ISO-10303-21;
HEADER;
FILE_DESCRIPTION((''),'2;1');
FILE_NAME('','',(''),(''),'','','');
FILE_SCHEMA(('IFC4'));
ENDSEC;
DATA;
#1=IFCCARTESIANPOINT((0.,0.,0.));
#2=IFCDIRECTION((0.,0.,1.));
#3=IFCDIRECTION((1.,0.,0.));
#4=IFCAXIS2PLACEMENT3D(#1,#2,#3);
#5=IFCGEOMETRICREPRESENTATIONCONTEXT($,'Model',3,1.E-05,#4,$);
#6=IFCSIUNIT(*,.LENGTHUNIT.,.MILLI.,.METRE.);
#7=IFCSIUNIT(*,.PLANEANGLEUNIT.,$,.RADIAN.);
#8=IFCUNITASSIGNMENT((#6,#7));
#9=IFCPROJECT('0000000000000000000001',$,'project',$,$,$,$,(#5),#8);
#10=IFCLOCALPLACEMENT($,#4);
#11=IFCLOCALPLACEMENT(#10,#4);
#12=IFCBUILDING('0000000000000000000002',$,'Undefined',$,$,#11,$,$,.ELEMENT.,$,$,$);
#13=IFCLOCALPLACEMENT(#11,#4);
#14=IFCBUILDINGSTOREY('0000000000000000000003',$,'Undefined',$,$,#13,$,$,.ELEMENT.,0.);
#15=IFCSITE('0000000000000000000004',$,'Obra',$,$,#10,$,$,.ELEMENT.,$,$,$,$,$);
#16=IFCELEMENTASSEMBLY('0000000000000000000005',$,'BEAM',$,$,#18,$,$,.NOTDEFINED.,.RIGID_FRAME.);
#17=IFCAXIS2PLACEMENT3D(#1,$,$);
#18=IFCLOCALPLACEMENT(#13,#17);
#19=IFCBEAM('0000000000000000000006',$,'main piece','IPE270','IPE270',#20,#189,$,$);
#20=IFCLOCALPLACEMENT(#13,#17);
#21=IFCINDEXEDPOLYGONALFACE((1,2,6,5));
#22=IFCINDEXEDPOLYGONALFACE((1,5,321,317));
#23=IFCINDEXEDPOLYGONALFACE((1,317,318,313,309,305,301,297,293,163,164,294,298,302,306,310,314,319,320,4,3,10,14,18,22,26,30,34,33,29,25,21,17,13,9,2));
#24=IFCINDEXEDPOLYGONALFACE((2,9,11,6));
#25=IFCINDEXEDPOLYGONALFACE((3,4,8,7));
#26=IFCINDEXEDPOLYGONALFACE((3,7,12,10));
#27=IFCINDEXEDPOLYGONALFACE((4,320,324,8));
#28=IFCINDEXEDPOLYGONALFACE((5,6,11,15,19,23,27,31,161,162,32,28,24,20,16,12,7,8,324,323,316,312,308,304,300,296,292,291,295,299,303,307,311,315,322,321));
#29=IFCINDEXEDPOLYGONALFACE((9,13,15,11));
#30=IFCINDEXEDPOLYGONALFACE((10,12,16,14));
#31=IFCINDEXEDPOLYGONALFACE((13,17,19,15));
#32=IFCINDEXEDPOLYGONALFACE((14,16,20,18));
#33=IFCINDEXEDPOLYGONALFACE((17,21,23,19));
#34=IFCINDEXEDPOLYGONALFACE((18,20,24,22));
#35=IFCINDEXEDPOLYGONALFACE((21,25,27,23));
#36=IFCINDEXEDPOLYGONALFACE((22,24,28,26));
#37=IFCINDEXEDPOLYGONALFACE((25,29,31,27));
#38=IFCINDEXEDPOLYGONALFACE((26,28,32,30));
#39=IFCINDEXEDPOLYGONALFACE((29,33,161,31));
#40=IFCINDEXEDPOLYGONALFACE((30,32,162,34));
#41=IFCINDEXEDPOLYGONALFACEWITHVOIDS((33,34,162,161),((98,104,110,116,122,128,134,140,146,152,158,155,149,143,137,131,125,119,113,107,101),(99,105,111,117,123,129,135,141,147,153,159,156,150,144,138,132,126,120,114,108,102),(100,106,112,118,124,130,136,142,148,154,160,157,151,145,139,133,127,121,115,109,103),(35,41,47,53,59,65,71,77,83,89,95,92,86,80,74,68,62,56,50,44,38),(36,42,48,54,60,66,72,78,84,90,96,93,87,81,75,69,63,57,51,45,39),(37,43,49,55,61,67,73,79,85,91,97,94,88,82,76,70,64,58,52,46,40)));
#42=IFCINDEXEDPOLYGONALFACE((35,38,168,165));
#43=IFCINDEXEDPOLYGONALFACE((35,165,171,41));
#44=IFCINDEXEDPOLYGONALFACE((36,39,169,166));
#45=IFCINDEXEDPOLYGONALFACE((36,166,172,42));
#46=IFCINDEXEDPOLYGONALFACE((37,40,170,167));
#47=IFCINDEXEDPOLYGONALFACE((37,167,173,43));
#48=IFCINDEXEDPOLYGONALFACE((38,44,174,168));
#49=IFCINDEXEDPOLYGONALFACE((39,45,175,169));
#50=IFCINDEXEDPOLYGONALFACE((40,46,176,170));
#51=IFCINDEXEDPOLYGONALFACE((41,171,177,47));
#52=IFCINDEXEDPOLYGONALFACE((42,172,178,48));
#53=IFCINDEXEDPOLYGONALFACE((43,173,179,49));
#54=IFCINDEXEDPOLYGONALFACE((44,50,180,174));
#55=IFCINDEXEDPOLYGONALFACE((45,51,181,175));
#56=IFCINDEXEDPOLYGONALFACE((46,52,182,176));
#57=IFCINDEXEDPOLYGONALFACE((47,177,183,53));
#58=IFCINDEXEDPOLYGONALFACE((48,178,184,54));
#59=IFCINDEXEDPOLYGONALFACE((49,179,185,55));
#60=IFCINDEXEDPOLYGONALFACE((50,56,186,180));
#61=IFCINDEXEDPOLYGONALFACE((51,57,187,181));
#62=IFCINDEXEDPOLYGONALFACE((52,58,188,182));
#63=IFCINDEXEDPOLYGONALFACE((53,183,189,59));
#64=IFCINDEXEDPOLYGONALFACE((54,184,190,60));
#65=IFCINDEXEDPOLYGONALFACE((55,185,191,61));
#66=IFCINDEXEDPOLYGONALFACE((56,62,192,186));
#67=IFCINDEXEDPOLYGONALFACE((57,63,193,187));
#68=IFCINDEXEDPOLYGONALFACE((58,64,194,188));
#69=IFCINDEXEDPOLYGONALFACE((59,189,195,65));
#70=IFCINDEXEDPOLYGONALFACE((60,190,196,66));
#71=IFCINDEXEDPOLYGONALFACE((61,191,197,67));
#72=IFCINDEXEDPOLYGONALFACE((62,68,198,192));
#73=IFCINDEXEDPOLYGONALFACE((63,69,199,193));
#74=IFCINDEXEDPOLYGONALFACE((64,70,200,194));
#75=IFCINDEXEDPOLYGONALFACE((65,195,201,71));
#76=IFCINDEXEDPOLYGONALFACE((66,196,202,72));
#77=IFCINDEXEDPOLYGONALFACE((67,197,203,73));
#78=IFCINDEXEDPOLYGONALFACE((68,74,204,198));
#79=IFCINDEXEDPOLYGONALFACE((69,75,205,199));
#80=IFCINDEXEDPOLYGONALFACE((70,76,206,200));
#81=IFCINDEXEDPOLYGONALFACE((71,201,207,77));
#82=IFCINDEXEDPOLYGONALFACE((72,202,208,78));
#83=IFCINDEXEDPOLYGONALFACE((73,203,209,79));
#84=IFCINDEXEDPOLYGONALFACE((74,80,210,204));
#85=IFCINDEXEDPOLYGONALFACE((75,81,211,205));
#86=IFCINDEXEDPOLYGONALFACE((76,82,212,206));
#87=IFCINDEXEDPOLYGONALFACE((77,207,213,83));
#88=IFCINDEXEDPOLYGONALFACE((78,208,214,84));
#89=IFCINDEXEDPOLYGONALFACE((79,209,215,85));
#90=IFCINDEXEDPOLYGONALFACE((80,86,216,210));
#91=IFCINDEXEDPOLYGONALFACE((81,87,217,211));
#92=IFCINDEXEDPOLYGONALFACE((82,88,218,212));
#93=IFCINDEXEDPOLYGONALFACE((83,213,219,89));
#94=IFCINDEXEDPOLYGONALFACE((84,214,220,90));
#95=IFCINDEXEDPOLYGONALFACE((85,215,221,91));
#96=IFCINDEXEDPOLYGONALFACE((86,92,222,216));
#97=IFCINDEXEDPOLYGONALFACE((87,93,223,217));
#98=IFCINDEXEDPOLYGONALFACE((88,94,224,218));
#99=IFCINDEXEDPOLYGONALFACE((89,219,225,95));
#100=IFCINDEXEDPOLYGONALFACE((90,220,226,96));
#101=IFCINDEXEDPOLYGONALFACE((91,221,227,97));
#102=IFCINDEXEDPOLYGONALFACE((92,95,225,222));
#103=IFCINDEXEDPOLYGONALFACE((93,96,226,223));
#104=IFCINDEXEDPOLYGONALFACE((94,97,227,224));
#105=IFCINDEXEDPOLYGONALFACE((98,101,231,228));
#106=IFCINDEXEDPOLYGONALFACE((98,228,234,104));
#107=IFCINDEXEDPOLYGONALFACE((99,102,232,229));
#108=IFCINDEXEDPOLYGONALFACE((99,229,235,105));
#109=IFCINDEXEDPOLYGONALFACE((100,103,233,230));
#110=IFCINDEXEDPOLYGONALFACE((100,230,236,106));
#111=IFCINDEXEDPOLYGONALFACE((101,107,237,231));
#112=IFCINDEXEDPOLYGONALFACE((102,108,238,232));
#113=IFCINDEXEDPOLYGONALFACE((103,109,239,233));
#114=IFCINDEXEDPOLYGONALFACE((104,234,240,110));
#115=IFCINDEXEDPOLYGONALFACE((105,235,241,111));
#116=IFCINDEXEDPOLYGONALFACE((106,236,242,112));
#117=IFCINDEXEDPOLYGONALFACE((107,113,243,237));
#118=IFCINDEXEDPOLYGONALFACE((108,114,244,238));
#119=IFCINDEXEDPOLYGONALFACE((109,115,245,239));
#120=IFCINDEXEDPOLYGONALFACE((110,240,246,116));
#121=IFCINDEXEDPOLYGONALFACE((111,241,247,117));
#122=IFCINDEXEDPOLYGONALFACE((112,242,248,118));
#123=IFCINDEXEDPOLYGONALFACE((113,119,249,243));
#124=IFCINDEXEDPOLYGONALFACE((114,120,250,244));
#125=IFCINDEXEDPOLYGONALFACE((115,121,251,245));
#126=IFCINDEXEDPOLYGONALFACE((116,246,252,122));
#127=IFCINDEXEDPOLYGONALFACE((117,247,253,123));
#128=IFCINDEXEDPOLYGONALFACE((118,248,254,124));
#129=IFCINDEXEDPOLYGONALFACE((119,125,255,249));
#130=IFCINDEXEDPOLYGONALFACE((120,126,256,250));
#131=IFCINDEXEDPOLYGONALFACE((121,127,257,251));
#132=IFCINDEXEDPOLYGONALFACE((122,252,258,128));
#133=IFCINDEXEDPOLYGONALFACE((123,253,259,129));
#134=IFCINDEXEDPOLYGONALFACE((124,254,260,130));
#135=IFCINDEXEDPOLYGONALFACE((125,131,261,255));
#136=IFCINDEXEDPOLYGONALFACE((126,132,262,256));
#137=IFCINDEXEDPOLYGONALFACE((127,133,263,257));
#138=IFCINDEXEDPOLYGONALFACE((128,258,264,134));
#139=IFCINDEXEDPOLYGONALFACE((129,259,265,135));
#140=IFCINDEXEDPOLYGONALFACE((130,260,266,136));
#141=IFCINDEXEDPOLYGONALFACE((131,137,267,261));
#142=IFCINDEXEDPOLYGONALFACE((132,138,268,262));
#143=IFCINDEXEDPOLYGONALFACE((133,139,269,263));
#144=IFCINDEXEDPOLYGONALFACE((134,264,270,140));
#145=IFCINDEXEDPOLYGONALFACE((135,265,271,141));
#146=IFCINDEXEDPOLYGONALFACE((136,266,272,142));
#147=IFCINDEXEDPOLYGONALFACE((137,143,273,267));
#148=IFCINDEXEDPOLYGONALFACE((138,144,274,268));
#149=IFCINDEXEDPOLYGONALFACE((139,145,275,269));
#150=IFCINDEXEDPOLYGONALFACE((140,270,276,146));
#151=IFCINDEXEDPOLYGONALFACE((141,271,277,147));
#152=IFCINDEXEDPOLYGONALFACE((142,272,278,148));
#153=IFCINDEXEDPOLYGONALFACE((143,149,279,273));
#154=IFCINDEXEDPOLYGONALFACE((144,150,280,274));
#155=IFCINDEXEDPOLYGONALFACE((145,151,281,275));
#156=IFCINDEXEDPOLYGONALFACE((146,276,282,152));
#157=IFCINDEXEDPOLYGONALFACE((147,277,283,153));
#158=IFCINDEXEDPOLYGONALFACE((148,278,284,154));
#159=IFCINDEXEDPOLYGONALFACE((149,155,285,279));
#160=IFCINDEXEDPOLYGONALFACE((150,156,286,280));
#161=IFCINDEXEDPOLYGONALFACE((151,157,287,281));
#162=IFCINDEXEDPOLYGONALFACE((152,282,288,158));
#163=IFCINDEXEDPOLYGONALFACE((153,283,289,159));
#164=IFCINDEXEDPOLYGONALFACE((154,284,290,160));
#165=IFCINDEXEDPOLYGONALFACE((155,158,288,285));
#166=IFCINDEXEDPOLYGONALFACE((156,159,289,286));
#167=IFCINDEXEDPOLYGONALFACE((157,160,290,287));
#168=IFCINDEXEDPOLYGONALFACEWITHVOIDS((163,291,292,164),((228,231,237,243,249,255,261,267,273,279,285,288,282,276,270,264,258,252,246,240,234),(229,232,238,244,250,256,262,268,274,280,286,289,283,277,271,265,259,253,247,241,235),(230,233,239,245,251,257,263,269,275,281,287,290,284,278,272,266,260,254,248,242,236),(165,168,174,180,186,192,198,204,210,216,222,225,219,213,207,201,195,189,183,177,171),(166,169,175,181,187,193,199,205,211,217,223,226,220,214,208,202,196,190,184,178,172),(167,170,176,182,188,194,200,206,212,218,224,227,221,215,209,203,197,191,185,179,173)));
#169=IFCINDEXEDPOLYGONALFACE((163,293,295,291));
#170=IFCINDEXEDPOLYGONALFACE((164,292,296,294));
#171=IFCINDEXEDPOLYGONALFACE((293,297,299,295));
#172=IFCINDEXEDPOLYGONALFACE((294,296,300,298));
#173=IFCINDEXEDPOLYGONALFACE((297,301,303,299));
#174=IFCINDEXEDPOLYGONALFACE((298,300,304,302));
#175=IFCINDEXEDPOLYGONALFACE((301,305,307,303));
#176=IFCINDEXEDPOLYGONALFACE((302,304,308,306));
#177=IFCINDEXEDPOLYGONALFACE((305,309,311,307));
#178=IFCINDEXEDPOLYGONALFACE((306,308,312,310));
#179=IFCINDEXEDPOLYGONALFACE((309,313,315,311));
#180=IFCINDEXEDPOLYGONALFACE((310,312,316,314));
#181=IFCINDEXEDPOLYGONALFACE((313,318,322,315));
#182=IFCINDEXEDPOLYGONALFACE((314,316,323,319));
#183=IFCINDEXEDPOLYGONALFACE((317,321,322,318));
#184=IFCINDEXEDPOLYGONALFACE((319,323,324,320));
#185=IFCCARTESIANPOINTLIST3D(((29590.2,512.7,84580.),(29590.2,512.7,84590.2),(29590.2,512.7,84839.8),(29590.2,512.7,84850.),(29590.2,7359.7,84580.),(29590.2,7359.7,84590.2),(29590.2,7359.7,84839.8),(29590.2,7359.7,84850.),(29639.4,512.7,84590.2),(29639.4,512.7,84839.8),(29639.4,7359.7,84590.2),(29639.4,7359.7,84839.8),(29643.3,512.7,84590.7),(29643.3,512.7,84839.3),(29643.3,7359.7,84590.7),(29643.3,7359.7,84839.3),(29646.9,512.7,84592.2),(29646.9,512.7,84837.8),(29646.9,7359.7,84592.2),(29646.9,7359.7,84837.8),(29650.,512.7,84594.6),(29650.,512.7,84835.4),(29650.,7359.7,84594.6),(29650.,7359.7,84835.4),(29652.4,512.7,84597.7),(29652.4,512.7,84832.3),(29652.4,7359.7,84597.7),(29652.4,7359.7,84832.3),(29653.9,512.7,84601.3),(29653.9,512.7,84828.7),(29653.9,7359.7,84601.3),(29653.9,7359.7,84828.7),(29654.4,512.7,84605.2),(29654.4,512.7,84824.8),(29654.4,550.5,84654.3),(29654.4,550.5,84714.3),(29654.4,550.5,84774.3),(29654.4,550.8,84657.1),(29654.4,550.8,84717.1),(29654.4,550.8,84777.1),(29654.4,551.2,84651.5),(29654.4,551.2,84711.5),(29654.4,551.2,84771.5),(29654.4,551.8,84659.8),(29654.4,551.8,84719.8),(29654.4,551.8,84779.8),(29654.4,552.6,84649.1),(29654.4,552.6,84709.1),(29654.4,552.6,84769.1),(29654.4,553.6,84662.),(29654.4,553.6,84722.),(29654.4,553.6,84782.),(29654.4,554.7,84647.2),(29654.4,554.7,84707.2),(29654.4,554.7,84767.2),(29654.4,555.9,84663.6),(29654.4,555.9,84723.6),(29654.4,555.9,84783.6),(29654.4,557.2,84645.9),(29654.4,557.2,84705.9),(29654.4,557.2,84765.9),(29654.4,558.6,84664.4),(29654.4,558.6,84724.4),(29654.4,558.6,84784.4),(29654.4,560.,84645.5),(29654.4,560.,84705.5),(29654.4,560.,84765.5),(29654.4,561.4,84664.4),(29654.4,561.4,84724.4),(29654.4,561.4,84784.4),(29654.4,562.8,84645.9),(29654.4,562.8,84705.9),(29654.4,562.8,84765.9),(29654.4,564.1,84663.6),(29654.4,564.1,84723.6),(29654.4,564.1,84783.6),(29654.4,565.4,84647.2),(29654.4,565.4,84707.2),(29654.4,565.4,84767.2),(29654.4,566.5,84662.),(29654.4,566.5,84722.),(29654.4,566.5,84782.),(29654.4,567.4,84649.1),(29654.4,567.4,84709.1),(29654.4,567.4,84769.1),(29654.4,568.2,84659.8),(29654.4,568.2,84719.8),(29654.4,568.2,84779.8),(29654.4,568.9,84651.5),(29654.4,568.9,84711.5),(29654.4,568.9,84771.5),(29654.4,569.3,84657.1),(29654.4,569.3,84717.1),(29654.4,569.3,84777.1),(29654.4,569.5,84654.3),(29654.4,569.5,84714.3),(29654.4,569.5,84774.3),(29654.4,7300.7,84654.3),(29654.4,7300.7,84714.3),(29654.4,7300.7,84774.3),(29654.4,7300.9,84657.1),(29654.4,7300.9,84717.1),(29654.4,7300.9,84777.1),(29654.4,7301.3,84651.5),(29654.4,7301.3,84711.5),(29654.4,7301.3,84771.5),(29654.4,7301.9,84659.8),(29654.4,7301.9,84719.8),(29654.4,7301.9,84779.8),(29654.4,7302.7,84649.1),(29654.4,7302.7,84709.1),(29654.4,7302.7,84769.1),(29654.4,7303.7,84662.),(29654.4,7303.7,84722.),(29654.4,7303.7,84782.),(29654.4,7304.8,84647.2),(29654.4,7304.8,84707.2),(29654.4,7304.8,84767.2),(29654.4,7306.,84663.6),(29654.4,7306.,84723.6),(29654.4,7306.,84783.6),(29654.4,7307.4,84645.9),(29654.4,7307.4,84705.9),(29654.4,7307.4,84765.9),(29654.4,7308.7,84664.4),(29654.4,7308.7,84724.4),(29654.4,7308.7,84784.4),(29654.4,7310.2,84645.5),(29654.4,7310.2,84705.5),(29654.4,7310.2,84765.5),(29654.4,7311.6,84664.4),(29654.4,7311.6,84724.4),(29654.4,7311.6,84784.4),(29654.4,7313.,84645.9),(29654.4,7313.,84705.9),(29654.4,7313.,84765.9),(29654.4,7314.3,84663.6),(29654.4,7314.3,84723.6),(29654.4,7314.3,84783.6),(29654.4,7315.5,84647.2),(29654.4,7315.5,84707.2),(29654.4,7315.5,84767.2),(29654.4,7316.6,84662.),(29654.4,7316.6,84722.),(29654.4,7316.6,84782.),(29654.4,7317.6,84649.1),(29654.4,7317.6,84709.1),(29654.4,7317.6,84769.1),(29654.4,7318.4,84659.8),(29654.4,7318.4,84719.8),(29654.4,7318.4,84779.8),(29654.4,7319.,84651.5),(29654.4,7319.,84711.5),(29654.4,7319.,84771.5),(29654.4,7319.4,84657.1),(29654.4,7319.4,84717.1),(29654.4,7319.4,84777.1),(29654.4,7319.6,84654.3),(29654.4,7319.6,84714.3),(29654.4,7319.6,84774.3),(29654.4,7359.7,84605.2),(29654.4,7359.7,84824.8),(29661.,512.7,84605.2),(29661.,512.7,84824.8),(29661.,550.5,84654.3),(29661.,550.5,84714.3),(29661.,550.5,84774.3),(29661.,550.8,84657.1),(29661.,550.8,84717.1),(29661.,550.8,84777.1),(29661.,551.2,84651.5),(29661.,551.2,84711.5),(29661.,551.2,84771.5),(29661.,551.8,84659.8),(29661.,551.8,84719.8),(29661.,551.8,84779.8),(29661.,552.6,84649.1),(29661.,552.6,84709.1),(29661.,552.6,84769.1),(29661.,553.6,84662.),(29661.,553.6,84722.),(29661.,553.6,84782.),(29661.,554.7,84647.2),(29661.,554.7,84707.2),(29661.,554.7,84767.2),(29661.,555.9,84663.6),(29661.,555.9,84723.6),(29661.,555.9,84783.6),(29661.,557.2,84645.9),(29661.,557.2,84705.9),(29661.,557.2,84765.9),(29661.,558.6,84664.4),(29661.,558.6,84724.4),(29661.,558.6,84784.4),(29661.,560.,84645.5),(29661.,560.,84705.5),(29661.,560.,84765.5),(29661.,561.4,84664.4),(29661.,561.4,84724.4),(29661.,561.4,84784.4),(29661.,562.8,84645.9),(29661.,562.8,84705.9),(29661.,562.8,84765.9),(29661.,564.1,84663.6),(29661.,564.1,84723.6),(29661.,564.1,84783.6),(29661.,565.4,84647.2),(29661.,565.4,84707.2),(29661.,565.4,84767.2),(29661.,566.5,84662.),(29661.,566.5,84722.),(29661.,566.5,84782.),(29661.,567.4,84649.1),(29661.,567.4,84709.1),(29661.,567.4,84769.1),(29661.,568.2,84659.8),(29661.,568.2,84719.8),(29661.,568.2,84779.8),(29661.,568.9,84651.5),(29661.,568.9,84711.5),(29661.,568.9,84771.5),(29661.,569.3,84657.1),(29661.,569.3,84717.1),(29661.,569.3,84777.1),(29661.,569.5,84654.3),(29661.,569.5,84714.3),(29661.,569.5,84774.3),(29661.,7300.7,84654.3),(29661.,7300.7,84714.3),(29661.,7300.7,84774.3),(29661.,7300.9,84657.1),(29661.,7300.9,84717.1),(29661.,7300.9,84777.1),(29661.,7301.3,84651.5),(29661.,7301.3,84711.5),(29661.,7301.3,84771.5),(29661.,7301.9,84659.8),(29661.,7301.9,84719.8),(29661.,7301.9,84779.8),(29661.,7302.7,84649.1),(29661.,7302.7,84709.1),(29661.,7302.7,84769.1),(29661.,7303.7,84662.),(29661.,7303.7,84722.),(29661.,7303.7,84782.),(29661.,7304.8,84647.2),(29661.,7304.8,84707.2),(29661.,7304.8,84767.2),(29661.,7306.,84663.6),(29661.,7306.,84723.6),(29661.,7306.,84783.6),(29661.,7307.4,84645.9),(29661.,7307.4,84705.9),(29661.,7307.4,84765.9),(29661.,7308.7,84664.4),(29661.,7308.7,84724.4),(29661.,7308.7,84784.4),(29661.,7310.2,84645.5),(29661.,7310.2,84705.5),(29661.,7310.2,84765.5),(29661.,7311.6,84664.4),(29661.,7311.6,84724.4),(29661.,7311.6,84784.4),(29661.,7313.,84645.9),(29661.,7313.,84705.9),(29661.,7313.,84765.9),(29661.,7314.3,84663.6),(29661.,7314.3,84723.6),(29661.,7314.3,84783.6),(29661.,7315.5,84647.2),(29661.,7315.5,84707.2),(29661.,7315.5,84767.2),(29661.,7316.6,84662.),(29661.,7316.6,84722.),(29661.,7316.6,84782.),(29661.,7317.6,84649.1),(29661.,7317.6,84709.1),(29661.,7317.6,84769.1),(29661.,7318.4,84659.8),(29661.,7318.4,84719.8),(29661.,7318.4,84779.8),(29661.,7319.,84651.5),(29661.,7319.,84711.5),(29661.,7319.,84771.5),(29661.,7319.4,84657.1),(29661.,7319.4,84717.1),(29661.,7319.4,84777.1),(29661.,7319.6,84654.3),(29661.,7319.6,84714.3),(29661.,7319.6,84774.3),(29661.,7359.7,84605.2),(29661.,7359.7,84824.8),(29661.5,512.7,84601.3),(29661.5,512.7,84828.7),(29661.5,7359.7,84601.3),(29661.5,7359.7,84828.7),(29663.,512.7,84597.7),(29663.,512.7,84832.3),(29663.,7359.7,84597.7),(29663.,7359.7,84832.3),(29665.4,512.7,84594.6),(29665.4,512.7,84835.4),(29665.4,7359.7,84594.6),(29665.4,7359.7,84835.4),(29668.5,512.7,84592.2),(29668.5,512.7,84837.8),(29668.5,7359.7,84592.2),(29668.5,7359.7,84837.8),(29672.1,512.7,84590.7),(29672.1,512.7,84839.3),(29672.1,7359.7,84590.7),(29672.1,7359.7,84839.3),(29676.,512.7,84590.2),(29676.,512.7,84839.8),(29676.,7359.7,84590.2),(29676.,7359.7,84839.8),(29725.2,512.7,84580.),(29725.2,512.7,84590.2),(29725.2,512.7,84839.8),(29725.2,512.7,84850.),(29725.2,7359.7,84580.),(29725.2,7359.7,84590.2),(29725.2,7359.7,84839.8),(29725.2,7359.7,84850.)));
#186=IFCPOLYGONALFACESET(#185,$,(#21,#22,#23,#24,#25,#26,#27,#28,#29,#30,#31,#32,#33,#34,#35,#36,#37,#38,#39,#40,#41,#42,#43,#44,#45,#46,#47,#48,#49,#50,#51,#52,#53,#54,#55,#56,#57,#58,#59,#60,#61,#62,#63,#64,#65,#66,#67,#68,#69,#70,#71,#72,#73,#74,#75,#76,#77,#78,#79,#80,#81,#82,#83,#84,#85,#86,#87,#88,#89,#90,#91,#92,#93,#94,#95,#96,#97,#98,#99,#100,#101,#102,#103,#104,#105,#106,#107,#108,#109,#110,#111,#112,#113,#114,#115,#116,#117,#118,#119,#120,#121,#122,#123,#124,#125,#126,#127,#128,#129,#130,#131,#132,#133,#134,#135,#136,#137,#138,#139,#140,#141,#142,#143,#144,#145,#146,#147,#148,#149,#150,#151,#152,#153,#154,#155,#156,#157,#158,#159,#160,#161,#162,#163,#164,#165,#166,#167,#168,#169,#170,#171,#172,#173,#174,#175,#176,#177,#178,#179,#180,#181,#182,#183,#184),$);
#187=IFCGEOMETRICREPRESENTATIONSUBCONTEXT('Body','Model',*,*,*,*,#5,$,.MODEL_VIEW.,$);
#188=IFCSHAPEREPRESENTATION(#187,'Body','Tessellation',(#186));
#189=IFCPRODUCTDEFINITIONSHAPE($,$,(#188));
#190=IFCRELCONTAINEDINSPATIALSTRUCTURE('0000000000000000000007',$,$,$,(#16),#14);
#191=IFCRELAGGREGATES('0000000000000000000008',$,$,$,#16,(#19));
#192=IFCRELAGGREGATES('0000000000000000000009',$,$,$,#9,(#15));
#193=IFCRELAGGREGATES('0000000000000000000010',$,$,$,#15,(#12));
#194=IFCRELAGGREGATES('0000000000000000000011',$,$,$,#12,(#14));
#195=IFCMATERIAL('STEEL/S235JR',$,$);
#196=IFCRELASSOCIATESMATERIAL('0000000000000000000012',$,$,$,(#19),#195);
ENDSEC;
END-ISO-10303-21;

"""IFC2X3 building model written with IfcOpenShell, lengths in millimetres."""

from ifc_helpers import new_model, si_unit, frame, origin_with_axes, origin_2d_with_axis, place, context, subcontext, project, spatial, circle, i_section, extrude, clip, halfspace, source, transform, mapped, material, element, aggregate, save


model = new_model("IFC2X3")

# Units and contexts
model_context = context("Model", 3, precision=1e-05, world=origin_with_axes())
body_context = subcontext(model_context, "Body", "Model", "MODEL_VIEW")
ifc_project = project(units=[si_unit("LENGTHUNIT", "METRE", prefix="MILLI"), si_unit("PLANEANGLEUNIT", "RADIAN")], contexts=[model_context])

# Site, building, storey
site_placement = place(None, origin_with_axes())
site = spatial("IfcSite", under=ifc_project, at=site_placement, Name="Obra", CompositionType="ELEMENT")
building_placement = place(site_placement, origin_with_axes())
building = spatial("IfcBuilding", under=site, at=building_placement, Name="Undefined", CompositionType="ELEMENT")
storey_placement = place(building_placement, origin_with_axes())
storey = spatial("IfcBuildingStorey", under=building, at=storey_placement, Name="Undefined", CompositionType="ELEMENT", Elevation=0.0)

# Element assembly, beam, openings
assembly_1_placement = place(storey_placement, origin_with_axes())
assembly_1 = element("IfcElementAssembly", 1, at=assembly_1_placement, inside=storey, Name="BEAM", AssemblyPlace="NOTDEFINED", PredefinedType="RIGID_FRAME")
ifc_material_1 = material(Name="STEEL/S235JR")
beam_1_placement = place(assembly_1_placement, frame((29657.7, 512.7, 84715.0), z_axis=(0.0, 0.0, 1.0), x_axis=(0.0, 1.0, 0.0)))
beam_1 = element("IfcBeam", 2, at=beam_1_placement, material=ifc_material_1, Name="main piece", Description="IPE270", ObjectType="IPE270", context=body_context, shape_type="Clipping", body=[
    clip(clip(extrude(i_section(OverallWidth=135.0, OverallDepth=270.0, WebThickness=6.6, FlangeThickness=10.2, FilletRadius=15.0, at=origin_2d_with_axis()), frame((6850.3, 0.0, 0.0), z_axis=(-1.0, 0.0, 0.0), x_axis=(0.0, -1.0, 0.0)), (0.0, 0.0, 1.0), 6850.3), halfspace(frame((6847.0, -60.0, -120.0), z_axis=(1.0, 0.000024, 0.0), x_axis=(0.0, 0.0, 1.0)), False)), halfspace(frame((-2.2, 60.0, -120.0), z_axis=(-1.0, -0.000021, 0.0), x_axis=(0.0, 0.0, 1.0)), False)),
])
shared_shape_1 = source(origin_with_axes(), body_context, "Body", "SweptSolid", [
    extrude(circle(Radius=9.5, at=origin_2d_with_axis()), frame((0.0, -3.4, 0.0), z_axis=(0.0, 1.0, 0.0), x_axis=(1.0, 0.0, 0.0)), (0.0, 0.0, 1.0), 6.8),
])
opening_1_placement = place(assembly_1_placement, frame((29657.7, 7360.2, 84835.0), z_axis=(0.000005, -1.0, 0.0), x_axis=(0.0, 0.0, -1.0)))
element("IfcOpeningElement", 3, at=opening_1_placement, cuts=beam_1, ObjectType="Opening", context=body_context, shape_type="MappedRepresentation", body=[
    mapped(shared_shape_1, transform((60.0, 0.0, 50.0))),
    mapped(shared_shape_1, transform((120.0, 0.0, 50.0))),
    mapped(shared_shape_1, transform((180.0, 0.0, 50.0))),
])
shared_shape_2 = source(origin_with_axes(), body_context, "Body", "SweptSolid", [
    extrude(circle(Radius=9.5, at=origin_2d_with_axis()), frame((0.0, -3.4, 0.0), z_axis=(0.0, 1.0, 0.0), x_axis=(1.0, 0.0, 0.0)), (0.0, 0.0, 1.0), 6.8),
])
opening_2_placement = place(assembly_1_placement, frame((29657.7, 510.0, 84835.0), z_axis=(-0.000002, 1.0, 0.0), x_axis=(0.0, 0.0, -1.0)))
element("IfcOpeningElement", 4, at=opening_2_placement, cuts=beam_1, ObjectType="Opening", context=body_context, shape_type="MappedRepresentation", body=[
    mapped(shared_shape_2, transform((60.0, 0.0, 50.0))),
    mapped(shared_shape_2, transform((120.0, 0.0, 50.0))),
    mapped(shared_shape_2, transform((180.0, 0.0, 50.0))),
])
aggregate(assembly_1, [beam_1])

save(model, "model.ifc")
